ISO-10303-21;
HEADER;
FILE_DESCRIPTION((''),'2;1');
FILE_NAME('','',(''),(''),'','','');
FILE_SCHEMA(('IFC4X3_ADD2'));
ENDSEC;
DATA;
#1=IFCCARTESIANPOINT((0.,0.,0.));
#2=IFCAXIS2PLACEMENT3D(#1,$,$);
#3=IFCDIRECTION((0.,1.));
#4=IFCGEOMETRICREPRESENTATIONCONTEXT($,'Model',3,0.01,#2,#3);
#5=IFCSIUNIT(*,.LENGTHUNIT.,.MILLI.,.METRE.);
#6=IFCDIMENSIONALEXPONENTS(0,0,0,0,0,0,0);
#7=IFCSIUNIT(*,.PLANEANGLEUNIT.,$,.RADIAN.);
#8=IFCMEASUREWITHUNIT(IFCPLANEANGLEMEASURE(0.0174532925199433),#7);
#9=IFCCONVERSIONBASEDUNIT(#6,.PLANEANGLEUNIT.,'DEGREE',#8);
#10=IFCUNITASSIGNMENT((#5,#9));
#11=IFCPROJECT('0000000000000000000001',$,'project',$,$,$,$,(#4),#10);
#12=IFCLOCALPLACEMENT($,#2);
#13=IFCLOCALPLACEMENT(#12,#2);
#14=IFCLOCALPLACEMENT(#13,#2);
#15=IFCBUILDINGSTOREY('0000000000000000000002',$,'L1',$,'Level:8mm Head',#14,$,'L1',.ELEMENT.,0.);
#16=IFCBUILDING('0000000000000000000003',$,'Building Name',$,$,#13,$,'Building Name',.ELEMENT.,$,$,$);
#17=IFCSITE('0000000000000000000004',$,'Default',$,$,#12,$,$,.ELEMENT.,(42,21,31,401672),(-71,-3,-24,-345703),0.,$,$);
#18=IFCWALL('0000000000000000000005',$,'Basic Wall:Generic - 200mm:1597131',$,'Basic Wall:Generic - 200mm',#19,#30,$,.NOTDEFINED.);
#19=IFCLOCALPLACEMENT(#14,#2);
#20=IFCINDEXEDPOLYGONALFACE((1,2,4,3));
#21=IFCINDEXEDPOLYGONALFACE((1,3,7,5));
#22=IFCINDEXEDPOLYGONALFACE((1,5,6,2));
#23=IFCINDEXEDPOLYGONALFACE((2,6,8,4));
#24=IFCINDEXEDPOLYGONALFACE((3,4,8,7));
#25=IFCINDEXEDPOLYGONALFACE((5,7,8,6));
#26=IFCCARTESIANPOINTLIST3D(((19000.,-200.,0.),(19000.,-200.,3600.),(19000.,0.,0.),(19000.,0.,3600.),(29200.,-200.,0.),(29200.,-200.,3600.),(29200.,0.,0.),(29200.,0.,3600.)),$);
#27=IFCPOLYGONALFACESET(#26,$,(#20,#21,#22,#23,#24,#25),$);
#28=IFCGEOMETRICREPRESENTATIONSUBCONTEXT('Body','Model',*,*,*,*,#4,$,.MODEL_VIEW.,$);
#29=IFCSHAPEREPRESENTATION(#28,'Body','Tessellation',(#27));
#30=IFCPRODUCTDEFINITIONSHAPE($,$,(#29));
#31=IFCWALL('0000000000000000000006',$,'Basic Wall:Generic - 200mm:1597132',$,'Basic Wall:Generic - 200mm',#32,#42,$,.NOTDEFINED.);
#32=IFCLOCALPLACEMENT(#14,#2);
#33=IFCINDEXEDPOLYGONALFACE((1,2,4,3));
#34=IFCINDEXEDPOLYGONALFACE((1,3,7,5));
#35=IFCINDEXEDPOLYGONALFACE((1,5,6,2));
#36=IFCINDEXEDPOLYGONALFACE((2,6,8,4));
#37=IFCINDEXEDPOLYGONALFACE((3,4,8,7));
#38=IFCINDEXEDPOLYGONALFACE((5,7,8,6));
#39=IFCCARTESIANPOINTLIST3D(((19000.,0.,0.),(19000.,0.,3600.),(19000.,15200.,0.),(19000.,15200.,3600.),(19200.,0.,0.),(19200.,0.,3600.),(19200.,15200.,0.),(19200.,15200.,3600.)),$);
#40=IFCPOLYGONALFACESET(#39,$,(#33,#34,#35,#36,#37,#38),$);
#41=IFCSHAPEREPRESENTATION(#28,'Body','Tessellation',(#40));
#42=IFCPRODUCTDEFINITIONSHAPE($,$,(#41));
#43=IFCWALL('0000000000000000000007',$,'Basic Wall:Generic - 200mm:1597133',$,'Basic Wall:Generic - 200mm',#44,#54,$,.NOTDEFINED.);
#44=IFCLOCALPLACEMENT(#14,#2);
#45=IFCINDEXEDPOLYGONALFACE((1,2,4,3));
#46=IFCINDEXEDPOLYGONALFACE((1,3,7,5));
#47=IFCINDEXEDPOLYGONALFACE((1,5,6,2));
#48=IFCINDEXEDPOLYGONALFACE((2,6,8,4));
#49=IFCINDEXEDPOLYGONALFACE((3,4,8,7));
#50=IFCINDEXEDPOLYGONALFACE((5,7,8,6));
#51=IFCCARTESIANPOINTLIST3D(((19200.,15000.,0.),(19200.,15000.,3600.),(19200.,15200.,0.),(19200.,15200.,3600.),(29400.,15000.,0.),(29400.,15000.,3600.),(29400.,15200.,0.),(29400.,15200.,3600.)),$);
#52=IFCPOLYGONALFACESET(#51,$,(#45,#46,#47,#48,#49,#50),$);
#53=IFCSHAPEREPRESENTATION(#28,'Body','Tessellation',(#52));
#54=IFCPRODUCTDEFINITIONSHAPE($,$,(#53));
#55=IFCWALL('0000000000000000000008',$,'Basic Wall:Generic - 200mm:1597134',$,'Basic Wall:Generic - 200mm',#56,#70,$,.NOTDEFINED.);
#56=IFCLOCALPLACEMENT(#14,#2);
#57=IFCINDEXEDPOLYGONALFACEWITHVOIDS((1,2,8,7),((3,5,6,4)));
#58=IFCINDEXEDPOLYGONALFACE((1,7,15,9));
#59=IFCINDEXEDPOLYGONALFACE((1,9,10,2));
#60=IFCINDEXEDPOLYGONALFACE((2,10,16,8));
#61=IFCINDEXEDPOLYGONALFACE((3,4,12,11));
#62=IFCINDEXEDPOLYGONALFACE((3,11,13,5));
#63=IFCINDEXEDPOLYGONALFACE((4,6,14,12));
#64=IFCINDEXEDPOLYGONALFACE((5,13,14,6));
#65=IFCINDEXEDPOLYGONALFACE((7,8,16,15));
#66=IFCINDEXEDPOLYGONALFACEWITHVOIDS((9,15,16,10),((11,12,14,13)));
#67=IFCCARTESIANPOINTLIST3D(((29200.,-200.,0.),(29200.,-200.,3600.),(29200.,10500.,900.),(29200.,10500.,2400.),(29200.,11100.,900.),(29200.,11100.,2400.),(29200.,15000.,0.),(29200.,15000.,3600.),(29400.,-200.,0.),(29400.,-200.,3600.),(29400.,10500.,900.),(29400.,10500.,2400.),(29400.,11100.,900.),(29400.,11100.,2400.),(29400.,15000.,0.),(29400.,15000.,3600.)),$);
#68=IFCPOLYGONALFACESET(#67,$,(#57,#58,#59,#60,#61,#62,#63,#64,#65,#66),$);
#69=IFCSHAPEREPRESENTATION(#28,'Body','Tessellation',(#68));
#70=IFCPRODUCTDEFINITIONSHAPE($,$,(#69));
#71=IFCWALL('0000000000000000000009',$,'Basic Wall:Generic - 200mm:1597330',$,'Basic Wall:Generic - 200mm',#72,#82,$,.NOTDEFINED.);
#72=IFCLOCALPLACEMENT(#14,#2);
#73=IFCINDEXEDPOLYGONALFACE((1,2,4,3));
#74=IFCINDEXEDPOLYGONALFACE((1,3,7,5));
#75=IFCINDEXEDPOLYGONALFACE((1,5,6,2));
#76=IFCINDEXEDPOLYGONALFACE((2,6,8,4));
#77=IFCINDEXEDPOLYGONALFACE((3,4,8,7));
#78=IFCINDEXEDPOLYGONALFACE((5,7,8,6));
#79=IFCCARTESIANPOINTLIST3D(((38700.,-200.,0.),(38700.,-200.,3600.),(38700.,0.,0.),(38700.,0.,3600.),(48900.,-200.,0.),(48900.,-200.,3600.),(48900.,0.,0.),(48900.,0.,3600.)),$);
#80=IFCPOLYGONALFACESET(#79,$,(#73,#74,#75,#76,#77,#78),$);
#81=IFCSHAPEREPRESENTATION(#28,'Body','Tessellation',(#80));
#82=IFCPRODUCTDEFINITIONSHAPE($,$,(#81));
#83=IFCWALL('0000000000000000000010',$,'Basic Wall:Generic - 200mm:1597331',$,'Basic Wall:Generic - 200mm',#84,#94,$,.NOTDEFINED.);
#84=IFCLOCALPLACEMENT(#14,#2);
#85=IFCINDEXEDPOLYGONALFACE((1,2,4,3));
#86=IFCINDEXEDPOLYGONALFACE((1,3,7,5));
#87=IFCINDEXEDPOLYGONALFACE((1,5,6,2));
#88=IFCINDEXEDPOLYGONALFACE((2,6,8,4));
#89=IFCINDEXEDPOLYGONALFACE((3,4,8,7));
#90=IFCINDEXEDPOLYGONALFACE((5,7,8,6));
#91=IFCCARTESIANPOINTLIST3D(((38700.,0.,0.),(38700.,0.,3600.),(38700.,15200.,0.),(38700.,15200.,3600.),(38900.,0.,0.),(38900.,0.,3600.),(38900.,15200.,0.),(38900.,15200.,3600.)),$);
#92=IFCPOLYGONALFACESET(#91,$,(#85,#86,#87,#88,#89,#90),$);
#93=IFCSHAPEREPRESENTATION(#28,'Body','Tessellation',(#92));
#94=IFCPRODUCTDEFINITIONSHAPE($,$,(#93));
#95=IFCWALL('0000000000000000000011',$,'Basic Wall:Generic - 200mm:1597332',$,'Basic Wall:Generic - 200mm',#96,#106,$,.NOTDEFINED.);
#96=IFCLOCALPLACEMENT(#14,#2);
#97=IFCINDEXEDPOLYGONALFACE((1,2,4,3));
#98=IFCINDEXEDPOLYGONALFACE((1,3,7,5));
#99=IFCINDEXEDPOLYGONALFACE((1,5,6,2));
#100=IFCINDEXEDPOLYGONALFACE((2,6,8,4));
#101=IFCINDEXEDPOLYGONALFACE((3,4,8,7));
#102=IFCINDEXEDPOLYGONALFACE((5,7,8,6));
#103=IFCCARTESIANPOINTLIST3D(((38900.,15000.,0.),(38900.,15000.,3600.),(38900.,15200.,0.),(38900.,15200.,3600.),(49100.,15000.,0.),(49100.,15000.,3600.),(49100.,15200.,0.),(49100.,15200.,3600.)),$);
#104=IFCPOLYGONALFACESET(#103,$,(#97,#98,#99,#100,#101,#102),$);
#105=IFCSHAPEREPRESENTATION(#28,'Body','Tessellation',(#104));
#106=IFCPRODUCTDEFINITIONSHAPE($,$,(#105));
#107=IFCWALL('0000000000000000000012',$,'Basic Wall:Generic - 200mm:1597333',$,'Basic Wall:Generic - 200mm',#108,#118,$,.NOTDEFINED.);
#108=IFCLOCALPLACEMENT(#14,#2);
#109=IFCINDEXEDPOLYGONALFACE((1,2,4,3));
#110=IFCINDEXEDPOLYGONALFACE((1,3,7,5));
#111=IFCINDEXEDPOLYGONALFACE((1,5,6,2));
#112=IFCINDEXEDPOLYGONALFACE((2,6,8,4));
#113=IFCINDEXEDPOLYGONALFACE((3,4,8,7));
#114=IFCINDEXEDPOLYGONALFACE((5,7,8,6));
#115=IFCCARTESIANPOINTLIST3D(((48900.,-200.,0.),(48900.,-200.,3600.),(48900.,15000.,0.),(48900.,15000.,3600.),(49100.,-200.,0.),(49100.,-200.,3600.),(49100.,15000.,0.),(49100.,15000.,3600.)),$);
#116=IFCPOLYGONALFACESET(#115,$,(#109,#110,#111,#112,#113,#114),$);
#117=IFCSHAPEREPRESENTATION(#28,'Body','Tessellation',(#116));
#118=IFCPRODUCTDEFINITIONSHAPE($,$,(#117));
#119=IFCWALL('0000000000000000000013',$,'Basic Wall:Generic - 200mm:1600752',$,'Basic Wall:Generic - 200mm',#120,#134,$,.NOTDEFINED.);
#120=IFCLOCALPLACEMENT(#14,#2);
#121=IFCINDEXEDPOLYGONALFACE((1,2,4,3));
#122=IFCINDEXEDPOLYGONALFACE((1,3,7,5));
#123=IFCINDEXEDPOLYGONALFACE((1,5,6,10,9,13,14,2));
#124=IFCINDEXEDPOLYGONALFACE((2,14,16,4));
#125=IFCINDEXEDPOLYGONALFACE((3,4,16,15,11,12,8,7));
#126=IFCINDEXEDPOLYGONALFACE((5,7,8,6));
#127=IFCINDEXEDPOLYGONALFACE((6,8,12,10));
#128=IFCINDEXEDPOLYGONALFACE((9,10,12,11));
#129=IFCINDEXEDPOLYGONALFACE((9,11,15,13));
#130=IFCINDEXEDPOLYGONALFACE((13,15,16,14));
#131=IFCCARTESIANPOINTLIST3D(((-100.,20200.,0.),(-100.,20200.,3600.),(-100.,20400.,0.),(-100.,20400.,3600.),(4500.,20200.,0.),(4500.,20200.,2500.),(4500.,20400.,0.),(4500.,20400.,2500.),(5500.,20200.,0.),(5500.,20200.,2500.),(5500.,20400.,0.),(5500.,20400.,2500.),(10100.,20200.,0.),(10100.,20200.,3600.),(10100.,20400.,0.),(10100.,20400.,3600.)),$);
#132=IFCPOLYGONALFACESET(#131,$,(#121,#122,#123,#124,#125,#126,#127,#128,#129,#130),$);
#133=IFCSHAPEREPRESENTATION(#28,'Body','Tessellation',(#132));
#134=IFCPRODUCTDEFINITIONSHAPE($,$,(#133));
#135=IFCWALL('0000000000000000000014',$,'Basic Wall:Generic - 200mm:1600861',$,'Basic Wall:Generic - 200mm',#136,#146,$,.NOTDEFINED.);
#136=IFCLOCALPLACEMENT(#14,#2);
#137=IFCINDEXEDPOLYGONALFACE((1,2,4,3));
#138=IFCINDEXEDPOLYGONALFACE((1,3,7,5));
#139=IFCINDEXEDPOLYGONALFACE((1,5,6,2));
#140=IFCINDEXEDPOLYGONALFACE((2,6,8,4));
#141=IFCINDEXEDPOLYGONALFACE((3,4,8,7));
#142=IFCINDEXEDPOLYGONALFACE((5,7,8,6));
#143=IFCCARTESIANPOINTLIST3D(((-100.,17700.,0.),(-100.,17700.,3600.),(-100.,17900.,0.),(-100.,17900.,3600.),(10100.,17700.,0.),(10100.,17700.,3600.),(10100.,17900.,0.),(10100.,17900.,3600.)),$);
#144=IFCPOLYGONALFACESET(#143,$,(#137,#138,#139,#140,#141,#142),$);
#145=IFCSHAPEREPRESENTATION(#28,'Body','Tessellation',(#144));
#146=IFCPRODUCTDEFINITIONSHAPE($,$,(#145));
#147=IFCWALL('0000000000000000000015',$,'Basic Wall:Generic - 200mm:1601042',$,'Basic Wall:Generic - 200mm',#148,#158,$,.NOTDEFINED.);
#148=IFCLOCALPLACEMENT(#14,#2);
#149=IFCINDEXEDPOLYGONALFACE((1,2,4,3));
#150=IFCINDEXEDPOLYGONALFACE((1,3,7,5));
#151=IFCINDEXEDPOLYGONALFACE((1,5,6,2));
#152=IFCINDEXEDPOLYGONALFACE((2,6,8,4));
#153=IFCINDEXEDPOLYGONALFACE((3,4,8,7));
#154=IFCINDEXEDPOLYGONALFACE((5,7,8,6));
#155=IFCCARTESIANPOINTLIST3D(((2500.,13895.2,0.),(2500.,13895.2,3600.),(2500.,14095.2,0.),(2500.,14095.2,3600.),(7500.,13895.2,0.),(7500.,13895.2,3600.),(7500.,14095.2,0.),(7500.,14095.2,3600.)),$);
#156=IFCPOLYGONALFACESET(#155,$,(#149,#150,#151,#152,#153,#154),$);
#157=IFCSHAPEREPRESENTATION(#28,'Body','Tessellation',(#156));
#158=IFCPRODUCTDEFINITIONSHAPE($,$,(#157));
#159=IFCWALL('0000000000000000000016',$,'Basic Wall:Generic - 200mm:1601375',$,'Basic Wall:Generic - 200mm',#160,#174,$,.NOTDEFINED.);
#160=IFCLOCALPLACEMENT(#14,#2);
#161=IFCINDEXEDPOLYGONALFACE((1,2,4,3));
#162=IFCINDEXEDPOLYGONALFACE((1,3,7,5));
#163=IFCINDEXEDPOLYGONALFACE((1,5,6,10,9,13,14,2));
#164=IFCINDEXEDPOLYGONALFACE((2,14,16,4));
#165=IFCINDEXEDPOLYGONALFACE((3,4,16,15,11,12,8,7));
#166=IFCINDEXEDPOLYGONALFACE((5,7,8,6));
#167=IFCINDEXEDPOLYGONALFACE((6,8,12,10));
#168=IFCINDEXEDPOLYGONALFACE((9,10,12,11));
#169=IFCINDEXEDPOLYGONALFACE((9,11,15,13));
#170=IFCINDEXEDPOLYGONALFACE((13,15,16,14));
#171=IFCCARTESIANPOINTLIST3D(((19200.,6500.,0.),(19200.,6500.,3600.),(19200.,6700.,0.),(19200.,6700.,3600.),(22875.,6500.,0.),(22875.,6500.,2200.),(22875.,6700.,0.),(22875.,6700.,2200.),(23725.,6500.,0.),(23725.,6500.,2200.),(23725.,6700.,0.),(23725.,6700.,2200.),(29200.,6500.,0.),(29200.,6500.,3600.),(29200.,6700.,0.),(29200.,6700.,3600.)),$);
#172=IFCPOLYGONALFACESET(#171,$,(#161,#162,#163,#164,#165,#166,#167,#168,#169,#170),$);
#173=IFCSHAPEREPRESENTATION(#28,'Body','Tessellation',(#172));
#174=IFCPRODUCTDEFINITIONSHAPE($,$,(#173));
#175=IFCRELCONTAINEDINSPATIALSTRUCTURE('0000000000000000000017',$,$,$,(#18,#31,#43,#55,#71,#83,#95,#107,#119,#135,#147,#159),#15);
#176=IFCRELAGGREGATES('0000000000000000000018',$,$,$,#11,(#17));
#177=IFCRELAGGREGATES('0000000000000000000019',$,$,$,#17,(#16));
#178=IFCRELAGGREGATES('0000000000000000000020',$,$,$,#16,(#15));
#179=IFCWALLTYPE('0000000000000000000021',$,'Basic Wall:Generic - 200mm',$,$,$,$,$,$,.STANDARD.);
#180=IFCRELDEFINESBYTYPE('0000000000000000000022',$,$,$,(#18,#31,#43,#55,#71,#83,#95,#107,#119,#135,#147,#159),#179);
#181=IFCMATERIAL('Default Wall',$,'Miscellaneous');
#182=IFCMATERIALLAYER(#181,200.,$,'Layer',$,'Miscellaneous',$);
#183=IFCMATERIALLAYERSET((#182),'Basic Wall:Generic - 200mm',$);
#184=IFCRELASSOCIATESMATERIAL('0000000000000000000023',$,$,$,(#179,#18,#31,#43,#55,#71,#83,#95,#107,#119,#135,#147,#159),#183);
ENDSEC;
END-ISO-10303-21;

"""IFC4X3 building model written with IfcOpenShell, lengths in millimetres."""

from ifc_helpers import new_model, entity, si_unit, converted_unit, direction, frame, frame_2d, origin, origin_2d_with_axis, place, context, subcontext, project, spatial, rectangle, extrude, material, layer, layer_set, type_object, element, save


model = new_model("IFC4X3")

# Units and contexts
model_context = context("Model", 3, precision=0.01, world=origin(), true_north=direction((0.0, 1.0)))
body_context = subcontext(model_context, "Body", "Model", "MODEL_VIEW")
ifc_project = project(units=[si_unit("LENGTHUNIT", "METRE", prefix="MILLI"), converted_unit("PLANEANGLEUNIT", "DEGREE", entity("IfcPlaneAngleMeasure", 0.0174532925199433), si_unit("PLANEANGLEUNIT", "RADIAN"), dimensions=[0, 0, 0, 0, 0, 0, 0])], contexts=[model_context])

# Site, building, storey
site_placement = place(None, origin())
site = spatial("IfcSite", under=ifc_project, at=site_placement, Name="Default", CompositionType="ELEMENT", RefLatitude=(42, 21, 31, 401672), RefLongitude=(-71, -3, -24, -345703), RefElevation=0.0)
building_placement = place(site_placement, origin())
building = spatial("IfcBuilding", under=site, at=building_placement, Name="Building Name", LongName="Building Name", CompositionType="ELEMENT")
storey_placement = place(building_placement, origin())
storey = spatial("IfcBuildingStorey", under=building, at=storey_placement, Name="L1", ObjectType="Level:8mm Head", LongName="L1", CompositionType="ELEMENT", Elevation=0.0)

# Walls
ifc_material_1 = material(Name="Default Wall", Category="Miscellaneous")
ifc_layer_1 = layer(ifc_material_1, 200.0, Name="Layer", Category="Miscellaneous")
ifc_layer_set_1 = layer_set([ifc_layer_1], Name="Basic Wall:Generic - 200mm")
wall_type_1 = type_object("IfcWallType", Name="Basic Wall:Generic - 200mm", PredefinedType="STANDARD", material=ifc_layer_set_1)
wall_1_placement = place(storey_placement, frame((19000.0, -100.0, 0.0)))
element("IfcWall", 1, at=wall_1_placement, inside=storey, type_object=wall_type_1, material=ifc_layer_set_1, Name="Basic Wall:Generic - 200mm:1597131", ObjectType="Basic Wall:Generic - 200mm", PredefinedType="NOTDEFINED", context=body_context, shape_type="SweptSolid", body=[
    extrude(rectangle(XDim=10200.0, YDim=200.0, at=frame_2d((5100.0, 0.0), x_axis=(-1.0, 0.0))), origin(), (0.0, 0.0, 1.0), 3600.0),
])
wall_2_placement = place(storey_placement, frame((19100.0, 15200.0, 0.0), z_axis=(0.0, 0.0, 1.0), x_axis=(0.0, -1.0, 0.0)))
element("IfcWall", 2, at=wall_2_placement, inside=storey, type_object=wall_type_1, material=ifc_layer_set_1, Name="Basic Wall:Generic - 200mm:1597132", ObjectType="Basic Wall:Generic - 200mm", PredefinedType="NOTDEFINED", context=body_context, shape_type="SweptSolid", body=[
    extrude(rectangle(XDim=15200.0, YDim=200.0, at=frame_2d((7600.0, 0.0), x_axis=(-1.0, 0.0))), origin(), (0.0, 0.0, 1.0), 3600.0),
])
wall_3_placement = place(storey_placement, frame((29400.0, 15100.0, 0.0), z_axis=(0.0, 0.0, 1.0), x_axis=(-1.0, 0.0, 0.0)))
element("IfcWall", 3, at=wall_3_placement, inside=storey, type_object=wall_type_1, material=ifc_layer_set_1, Name="Basic Wall:Generic - 200mm:1597133", ObjectType="Basic Wall:Generic - 200mm", PredefinedType="NOTDEFINED", context=body_context, shape_type="SweptSolid", body=[
    extrude(rectangle(XDim=10200.0, YDim=200.0, at=frame_2d((5100.0, 0.0), x_axis=(-1.0, 0.0))), origin(), (0.0, 0.0, 1.0), 3600.0),
])

# Wall, opening
wall_4_placement = place(storey_placement, frame((29300.0, -200.0, 0.0), z_axis=(0.0, 0.0, 1.0), x_axis=(0.0, 1.0, 0.0)))
wall_4 = element("IfcWall", 4, at=wall_4_placement, inside=storey, type_object=wall_type_1, material=ifc_layer_set_1, Name="Basic Wall:Generic - 200mm:1597134", ObjectType="Basic Wall:Generic - 200mm", PredefinedType="NOTDEFINED", context=body_context, shape_type="SweptSolid", body=[
    extrude(rectangle(XDim=15200.0, YDim=200.0, at=frame_2d((7600.0, 0.0), x_axis=(-1.0, 0.0))), origin(), (0.0, 0.0, 1.0), 3600.0),
])
opening_1_placement = place(wall_4_placement, frame((11300.0, 100.0, 900.0)))
element("IfcOpeningElement", 5, at=opening_1_placement, cuts=wall_4, PredefinedType="OPENING", context=body_context, shape_type="SweptSolid", body=[
    extrude(rectangle(XDim=1500.0, YDim=600.0, at=frame_2d((750.0, 300.0), x_axis=(-1.0, 0.0))), frame((0.0, 0.0, 0.0), z_axis=(0.0, -1.0, 0.0), x_axis=(0.0, 0.0, 1.0)), (0.0, 0.0, 1.0), 200.0),
])

# Walls
wall_5_placement = place(storey_placement, frame((38700.0, -100.0, 0.0)))
element("IfcWall", 6, at=wall_5_placement, inside=storey, type_object=wall_type_1, material=ifc_layer_set_1, Name="Basic Wall:Generic - 200mm:1597330", ObjectType="Basic Wall:Generic - 200mm", PredefinedType="NOTDEFINED", context=body_context, shape_type="SweptSolid", body=[
    extrude(rectangle(XDim=10200.0, YDim=200.0, at=frame_2d((5100.0, 0.0), x_axis=(-1.0, 0.0))), origin(), (0.0, 0.0, 1.0), 3600.0),
])
wall_6_placement = place(storey_placement, frame((38800.0, 15200.0, 0.0), z_axis=(0.0, 0.0, 1.0), x_axis=(0.0, -1.0, 0.0)))
element("IfcWall", 7, at=wall_6_placement, inside=storey, type_object=wall_type_1, material=ifc_layer_set_1, Name="Basic Wall:Generic - 200mm:1597331", ObjectType="Basic Wall:Generic - 200mm", PredefinedType="NOTDEFINED", context=body_context, shape_type="SweptSolid", body=[
    extrude(rectangle(XDim=15200.0, YDim=200.0, at=frame_2d((7600.0, 0.0), x_axis=(-1.0, 0.0))), origin(), (0.0, 0.0, 1.0), 3600.0),
])
wall_7_placement = place(storey_placement, frame((49100.0, 15100.0, 0.0), z_axis=(0.0, 0.0, 1.0), x_axis=(-1.0, 0.0, 0.0)))
element("IfcWall", 8, at=wall_7_placement, inside=storey, type_object=wall_type_1, material=ifc_layer_set_1, Name="Basic Wall:Generic - 200mm:1597332", ObjectType="Basic Wall:Generic - 200mm", PredefinedType="NOTDEFINED", context=body_context, shape_type="SweptSolid", body=[
    extrude(rectangle(XDim=10200.0, YDim=200.0, at=frame_2d((5100.0, 0.0), x_axis=(-1.0, 0.0))), origin(), (0.0, 0.0, 1.0), 3600.0),
])
wall_8_placement = place(storey_placement, frame((49000.0, -200.0, 0.0), z_axis=(0.0, 0.0, 1.0), x_axis=(0.0, 1.0, 0.0)))
element("IfcWall", 9, at=wall_8_placement, inside=storey, type_object=wall_type_1, material=ifc_layer_set_1, Name="Basic Wall:Generic - 200mm:1597333", ObjectType="Basic Wall:Generic - 200mm", PredefinedType="NOTDEFINED", context=body_context, shape_type="SweptSolid", body=[
    extrude(rectangle(XDim=15200.0, YDim=200.0, at=frame_2d((7600.0, 0.0), x_axis=(-1.0, 0.0))), origin(), (0.0, 0.0, 1.0), 3600.0),
])

# Wall, opening
wall_9_placement = place(storey_placement, frame((10100.0, 20300.0, 0.0), z_axis=(0.0, 0.0, 1.0), x_axis=(-1.0, 0.0, 0.0)))
wall_9 = element("IfcWall", 10, at=wall_9_placement, inside=storey, type_object=wall_type_1, material=ifc_layer_set_1, Name="Basic Wall:Generic - 200mm:1600752", ObjectType="Basic Wall:Generic - 200mm", PredefinedType="NOTDEFINED", context=body_context, shape_type="SweptSolid", body=[
    extrude(rectangle(XDim=10200.0, YDim=200.0, at=frame_2d((5100.0, 0.0), x_axis=(1.0, 0.0))), origin(), (0.0, 0.0, 1.0), 3600.0),
])
opening_2_placement = place(wall_9_placement, frame((5600.0, 100.0, 0.0)))
element("IfcOpeningElement", 11, at=opening_2_placement, cuts=wall_9, PredefinedType="OPENING", context=body_context, shape_type="SweptSolid", body=[
    extrude(rectangle(XDim=2500.0, YDim=1000.0, at=origin_2d_with_axis()), frame((-500.0, -200.0, 1250.0), z_axis=(0.0, 1.0, 0.0), x_axis=(0.0, 0.0, -1.0)), (0.0, 0.0, 1.0), 200.0),
])

# Walls
wall_10_placement = place(storey_placement, frame((10100.0, 17800.0, 0.0), z_axis=(0.0, 0.0, 1.0), x_axis=(-1.0, 0.0, 0.0)))
element("IfcWall", 12, at=wall_10_placement, inside=storey, type_object=wall_type_1, material=ifc_layer_set_1, Name="Basic Wall:Generic - 200mm:1600861", ObjectType="Basic Wall:Generic - 200mm", PredefinedType="NOTDEFINED", context=body_context, shape_type="SweptSolid", body=[
    extrude(rectangle(XDim=10200.0, YDim=200.0, at=frame_2d((5100.0, 0.0), x_axis=(-1.0, 0.0))), origin(), (0.0, 0.0, 1.0), 3600.0),
])
wall_11_placement = place(storey_placement, frame((7500.0, 13995.2, 0.0), z_axis=(0.0, 0.0, 1.0), x_axis=(-1.0, 0.0, 0.0)))
element("IfcWall", 13, at=wall_11_placement, inside=storey, type_object=wall_type_1, material=ifc_layer_set_1, Name="Basic Wall:Generic - 200mm:1601042", ObjectType="Basic Wall:Generic - 200mm", PredefinedType="NOTDEFINED", context=body_context, shape_type="SweptSolid", body=[
    extrude(rectangle(XDim=5000.0, YDim=200.0, at=frame_2d((2500.0, 0.0), x_axis=(-1.0, 0.0))), origin(), (0.0, 0.0, 1.0), 3600.0),
])

# Wall, opening
wall_12_placement = place(storey_placement, frame((29200.0, 6600.0, 0.0), z_axis=(0.0, 0.0, 1.0), x_axis=(-1.0, 0.0, 0.0)))
wall_12 = element("IfcWall", 14, at=wall_12_placement, inside=storey, type_object=wall_type_1, material=ifc_layer_set_1, Name="Basic Wall:Generic - 200mm:1601375", ObjectType="Basic Wall:Generic - 200mm", PredefinedType="NOTDEFINED", context=body_context, shape_type="SweptSolid", body=[
    extrude(rectangle(XDim=10000.0, YDim=200.0, at=frame_2d((5000.0, 0.0), x_axis=(1.0, 0.0))), origin(), (0.0, 0.0, 1.0), 3600.0),
])
opening_3_placement = place(wall_12_placement, frame((6325.0, 100.0, 0.0)))
element("IfcOpeningElement", 15, at=opening_3_placement, cuts=wall_12, PredefinedType="OPENING", context=body_context, shape_type="SweptSolid", body=[
    extrude(rectangle(XDim=2200.0, YDim=850.0, at=frame_2d((1100.0, 425.0), x_axis=(1.0, 0.0))), frame((0.0, 0.0, 0.0), z_axis=(0.0, -1.0, 0.0), x_axis=(0.0, 0.0, 1.0)), (0.0, 0.0, 1.0), 200.0),
])

save(model, "model.ifc")
